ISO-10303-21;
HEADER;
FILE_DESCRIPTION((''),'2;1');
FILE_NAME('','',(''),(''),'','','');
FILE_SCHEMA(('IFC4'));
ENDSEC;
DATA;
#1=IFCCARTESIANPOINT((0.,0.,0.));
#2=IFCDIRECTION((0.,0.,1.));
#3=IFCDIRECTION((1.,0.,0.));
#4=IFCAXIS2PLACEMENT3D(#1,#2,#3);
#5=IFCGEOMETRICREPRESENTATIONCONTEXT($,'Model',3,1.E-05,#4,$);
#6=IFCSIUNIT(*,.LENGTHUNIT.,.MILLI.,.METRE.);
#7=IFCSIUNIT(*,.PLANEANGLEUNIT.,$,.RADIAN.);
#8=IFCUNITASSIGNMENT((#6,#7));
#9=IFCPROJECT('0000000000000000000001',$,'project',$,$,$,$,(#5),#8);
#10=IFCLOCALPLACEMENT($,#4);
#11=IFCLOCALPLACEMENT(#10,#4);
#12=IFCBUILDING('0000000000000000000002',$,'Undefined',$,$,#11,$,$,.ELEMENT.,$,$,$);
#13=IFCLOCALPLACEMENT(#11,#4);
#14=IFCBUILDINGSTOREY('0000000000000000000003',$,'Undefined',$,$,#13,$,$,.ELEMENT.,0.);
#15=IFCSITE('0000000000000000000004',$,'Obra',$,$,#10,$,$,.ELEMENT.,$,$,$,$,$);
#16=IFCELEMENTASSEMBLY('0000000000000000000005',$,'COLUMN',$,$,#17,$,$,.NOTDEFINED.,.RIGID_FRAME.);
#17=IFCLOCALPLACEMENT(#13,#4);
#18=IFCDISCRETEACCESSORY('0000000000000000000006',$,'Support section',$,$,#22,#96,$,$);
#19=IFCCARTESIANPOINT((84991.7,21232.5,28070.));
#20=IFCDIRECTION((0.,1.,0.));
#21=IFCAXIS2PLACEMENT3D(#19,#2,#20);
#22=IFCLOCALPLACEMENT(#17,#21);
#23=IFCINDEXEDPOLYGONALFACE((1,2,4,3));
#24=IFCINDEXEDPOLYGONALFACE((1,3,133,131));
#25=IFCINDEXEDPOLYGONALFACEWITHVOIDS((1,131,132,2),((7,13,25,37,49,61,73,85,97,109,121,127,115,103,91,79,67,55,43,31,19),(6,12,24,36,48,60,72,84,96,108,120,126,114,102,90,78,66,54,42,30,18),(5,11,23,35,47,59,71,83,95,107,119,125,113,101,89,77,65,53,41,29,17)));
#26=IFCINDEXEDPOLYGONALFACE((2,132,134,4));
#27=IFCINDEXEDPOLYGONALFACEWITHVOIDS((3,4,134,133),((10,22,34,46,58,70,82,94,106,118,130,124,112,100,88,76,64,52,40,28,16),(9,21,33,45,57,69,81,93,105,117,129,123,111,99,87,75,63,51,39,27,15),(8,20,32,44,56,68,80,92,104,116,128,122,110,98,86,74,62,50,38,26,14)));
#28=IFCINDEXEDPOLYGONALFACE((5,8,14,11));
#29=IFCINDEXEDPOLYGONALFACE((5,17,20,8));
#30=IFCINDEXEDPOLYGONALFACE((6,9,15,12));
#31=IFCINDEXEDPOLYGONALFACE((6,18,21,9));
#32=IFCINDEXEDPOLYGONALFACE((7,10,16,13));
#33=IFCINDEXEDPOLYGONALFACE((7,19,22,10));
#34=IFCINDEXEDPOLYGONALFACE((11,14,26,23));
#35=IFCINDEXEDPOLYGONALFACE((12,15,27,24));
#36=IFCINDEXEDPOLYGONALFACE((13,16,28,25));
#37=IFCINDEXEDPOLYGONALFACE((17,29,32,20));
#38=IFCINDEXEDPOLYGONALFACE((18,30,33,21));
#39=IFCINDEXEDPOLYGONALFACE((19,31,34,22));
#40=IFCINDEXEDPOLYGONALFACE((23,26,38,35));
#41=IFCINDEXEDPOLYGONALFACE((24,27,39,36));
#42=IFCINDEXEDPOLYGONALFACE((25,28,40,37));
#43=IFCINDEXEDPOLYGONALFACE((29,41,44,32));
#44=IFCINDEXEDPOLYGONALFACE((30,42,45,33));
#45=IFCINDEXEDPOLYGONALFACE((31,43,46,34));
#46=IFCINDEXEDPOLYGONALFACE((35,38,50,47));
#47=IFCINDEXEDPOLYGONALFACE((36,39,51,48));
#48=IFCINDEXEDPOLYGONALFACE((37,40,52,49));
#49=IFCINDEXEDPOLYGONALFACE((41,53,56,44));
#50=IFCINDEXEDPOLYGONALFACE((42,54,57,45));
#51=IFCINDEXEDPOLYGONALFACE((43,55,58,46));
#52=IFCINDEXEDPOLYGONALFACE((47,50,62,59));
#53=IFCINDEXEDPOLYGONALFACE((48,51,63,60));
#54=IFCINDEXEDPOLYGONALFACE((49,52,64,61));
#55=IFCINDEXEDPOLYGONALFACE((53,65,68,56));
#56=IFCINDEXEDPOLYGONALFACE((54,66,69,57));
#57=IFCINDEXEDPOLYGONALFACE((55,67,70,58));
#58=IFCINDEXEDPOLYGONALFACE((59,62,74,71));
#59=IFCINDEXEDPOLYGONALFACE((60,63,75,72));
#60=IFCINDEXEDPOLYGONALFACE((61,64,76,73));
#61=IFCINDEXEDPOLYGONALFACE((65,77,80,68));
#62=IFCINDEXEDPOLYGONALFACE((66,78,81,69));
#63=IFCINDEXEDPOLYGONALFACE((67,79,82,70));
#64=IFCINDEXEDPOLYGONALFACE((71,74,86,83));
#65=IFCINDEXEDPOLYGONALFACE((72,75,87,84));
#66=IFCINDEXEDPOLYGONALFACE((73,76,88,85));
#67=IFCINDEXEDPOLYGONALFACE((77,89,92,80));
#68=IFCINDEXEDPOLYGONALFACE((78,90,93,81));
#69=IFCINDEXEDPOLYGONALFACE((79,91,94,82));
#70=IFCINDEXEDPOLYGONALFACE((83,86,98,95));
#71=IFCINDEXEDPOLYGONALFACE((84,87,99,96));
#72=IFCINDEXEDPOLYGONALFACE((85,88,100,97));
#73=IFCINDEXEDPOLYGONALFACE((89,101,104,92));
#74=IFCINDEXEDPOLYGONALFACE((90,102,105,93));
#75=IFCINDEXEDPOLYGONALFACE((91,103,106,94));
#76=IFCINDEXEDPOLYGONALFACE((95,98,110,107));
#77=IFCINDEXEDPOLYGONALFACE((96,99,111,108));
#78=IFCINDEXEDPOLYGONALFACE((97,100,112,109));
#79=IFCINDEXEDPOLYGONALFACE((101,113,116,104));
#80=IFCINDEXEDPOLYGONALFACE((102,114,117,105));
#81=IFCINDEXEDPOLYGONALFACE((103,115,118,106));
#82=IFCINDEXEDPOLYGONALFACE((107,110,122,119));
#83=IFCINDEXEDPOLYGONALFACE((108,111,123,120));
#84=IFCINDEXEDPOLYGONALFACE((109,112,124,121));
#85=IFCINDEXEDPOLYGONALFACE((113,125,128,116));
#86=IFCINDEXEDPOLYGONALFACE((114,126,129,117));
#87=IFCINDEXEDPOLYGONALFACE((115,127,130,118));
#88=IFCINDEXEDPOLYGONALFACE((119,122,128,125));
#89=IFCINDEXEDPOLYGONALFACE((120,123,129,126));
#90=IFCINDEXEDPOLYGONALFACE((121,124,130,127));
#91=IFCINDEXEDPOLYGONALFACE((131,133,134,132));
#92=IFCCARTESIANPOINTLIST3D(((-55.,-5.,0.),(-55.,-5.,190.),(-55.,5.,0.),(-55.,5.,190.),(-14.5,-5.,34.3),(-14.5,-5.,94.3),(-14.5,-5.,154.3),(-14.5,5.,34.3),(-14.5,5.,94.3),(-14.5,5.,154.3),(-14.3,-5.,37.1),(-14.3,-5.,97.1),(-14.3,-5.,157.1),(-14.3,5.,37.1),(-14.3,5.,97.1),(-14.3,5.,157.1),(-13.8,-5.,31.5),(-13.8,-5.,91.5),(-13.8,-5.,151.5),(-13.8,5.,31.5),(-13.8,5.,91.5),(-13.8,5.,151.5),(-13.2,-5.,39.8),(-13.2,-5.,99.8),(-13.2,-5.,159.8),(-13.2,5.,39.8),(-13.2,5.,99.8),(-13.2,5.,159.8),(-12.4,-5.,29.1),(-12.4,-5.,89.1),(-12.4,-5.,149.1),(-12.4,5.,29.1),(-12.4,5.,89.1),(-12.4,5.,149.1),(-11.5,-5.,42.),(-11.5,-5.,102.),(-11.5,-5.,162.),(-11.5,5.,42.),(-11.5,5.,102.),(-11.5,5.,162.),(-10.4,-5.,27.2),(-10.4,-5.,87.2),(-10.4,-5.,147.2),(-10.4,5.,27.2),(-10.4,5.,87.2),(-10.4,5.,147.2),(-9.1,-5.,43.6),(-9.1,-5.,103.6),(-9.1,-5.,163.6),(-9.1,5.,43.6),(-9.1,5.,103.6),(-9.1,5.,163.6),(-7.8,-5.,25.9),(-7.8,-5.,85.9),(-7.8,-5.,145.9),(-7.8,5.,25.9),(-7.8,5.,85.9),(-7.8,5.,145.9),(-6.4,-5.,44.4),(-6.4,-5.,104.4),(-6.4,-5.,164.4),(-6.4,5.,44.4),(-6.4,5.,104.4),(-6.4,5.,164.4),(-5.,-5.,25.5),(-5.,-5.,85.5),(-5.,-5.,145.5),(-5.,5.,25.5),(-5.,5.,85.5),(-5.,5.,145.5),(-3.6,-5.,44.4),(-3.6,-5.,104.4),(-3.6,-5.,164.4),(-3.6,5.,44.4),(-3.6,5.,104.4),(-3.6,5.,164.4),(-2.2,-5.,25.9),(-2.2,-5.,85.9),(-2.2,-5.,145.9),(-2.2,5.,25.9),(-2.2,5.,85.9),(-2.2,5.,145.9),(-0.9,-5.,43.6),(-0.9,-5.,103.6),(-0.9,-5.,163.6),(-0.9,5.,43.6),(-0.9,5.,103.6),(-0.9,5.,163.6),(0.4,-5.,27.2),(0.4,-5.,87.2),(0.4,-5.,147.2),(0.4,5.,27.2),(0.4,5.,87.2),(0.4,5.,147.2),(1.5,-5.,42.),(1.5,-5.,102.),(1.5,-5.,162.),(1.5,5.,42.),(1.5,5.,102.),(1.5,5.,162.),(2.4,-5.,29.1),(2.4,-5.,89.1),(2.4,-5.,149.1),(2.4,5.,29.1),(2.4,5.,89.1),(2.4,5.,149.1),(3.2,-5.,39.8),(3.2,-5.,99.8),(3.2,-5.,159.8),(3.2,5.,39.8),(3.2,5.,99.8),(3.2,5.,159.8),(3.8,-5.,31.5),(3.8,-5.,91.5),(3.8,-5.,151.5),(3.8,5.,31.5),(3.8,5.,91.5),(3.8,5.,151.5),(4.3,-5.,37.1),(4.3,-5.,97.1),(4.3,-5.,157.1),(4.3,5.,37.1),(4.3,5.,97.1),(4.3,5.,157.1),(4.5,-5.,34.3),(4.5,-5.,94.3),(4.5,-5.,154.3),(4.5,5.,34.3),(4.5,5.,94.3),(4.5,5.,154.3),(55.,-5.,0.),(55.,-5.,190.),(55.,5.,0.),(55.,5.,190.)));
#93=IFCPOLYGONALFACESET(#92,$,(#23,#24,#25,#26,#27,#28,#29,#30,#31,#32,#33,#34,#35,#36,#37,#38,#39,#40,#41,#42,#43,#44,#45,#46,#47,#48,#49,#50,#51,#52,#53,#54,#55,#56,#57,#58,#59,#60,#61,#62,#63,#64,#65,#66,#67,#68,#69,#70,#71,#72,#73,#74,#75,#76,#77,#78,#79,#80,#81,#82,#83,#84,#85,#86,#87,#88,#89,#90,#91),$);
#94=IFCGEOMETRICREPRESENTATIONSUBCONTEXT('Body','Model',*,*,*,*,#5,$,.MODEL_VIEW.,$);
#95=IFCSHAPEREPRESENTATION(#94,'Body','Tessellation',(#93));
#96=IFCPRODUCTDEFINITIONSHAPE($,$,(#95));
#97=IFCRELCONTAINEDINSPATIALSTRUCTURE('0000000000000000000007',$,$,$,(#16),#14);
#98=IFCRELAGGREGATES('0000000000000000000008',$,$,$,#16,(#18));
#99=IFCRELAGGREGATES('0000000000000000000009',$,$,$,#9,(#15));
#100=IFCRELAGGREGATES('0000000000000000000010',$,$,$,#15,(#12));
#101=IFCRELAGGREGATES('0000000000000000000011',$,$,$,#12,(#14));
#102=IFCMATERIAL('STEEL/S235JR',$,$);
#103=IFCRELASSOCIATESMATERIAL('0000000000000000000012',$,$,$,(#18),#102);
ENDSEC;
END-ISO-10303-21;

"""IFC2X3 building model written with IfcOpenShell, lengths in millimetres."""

from ifc_helpers import new_model, si_unit, frame, origin_with_axes, origin_2d_with_axis, place, context, subcontext, project, spatial, rectangle, circle, extrude, source, transform, mapped, material, element, aggregate, save


model = new_model("IFC2X3")

# Units and contexts
model_context = context("Model", 3, precision=1e-05, world=origin_with_axes())
body_context = subcontext(model_context, "Body", "Model", "MODEL_VIEW")
ifc_project = project(units=[si_unit("LENGTHUNIT", "METRE", prefix="MILLI"), si_unit("PLANEANGLEUNIT", "RADIAN")], contexts=[model_context])

# Site, building, storey
site_placement = place(None, origin_with_axes())
site = spatial("IfcSite", under=ifc_project, at=site_placement, Name="Obra", CompositionType="ELEMENT")
building_placement = place(site_placement, origin_with_axes())
building = spatial("IfcBuilding", under=site, at=building_placement, Name="Undefined", CompositionType="ELEMENT")
storey_placement = place(building_placement, origin_with_axes())
storey = spatial("IfcBuildingStorey", under=building, at=storey_placement, Name="Undefined", CompositionType="ELEMENT", Elevation=0.0)

# Element assembly
ifc_material = material(Name="STEEL/S235JR")
assembly_1_placement = place(storey_placement, origin_with_axes())
assembly_1 = element("IfcElementAssembly", 1, at=assembly_1_placement, inside=storey, Name="COLUMN", AssemblyPlace="NOTDEFINED", PredefinedType="RIGID_FRAME")

# Discrete accessory, opening
discrete_accessory_1_placement = place(assembly_1_placement, frame((84991.7, 21232.5, 28070.0), z_axis=(0.0, 0.0, 1.0), x_axis=(0.0, 1.0, 0.0)))
discrete_accessory_1 = element("IfcDiscreteAccessory", 2, at=discrete_accessory_1_placement, material=ifc_material, Name="Support section", context=body_context, shape_type="SweptSolid", body=[
    extrude(rectangle(XDim=10.0, YDim=110.0, at=origin_2d_with_axis()), frame((0.0, 0.0, 190.0), z_axis=(0.0, 0.0, -1.0), x_axis=(0.0, 1.0, 0.0)), (0.0, 0.0, 1.0), 190.0),
])
shared_shape_1 = source(origin_with_axes(), body_context, "Body", "SweptSolid", [
    extrude(circle(Radius=9.5, at=origin_2d_with_axis()), frame((0.0, -13.4, 0.0), z_axis=(0.0, 1.0, 0.0), x_axis=(1.0, 0.0, 0.0)), (0.0, 0.0, 1.0), 10.2),
])
opening_1_placement = place(assembly_1_placement, frame((85000.0, 21277.5, 28300.0), z_axis=(0.0, -1.0, 0.0), x_axis=(0.0, 0.0, -1.0)))
element("IfcOpeningElement", 3, at=opening_1_placement, cuts=discrete_accessory_1, ObjectType="Opening", context=body_context, shape_type="MappedRepresentation", body=[
    mapped(shared_shape_1, transform((75.0, 0.0, 50.0))),
    mapped(shared_shape_1, transform((135.0, 0.0, 50.0))),
    mapped(shared_shape_1, transform((195.0, 0.0, 50.0))),
])
aggregate(assembly_1, [discrete_accessory_1])

save(model, "model.ifc")
